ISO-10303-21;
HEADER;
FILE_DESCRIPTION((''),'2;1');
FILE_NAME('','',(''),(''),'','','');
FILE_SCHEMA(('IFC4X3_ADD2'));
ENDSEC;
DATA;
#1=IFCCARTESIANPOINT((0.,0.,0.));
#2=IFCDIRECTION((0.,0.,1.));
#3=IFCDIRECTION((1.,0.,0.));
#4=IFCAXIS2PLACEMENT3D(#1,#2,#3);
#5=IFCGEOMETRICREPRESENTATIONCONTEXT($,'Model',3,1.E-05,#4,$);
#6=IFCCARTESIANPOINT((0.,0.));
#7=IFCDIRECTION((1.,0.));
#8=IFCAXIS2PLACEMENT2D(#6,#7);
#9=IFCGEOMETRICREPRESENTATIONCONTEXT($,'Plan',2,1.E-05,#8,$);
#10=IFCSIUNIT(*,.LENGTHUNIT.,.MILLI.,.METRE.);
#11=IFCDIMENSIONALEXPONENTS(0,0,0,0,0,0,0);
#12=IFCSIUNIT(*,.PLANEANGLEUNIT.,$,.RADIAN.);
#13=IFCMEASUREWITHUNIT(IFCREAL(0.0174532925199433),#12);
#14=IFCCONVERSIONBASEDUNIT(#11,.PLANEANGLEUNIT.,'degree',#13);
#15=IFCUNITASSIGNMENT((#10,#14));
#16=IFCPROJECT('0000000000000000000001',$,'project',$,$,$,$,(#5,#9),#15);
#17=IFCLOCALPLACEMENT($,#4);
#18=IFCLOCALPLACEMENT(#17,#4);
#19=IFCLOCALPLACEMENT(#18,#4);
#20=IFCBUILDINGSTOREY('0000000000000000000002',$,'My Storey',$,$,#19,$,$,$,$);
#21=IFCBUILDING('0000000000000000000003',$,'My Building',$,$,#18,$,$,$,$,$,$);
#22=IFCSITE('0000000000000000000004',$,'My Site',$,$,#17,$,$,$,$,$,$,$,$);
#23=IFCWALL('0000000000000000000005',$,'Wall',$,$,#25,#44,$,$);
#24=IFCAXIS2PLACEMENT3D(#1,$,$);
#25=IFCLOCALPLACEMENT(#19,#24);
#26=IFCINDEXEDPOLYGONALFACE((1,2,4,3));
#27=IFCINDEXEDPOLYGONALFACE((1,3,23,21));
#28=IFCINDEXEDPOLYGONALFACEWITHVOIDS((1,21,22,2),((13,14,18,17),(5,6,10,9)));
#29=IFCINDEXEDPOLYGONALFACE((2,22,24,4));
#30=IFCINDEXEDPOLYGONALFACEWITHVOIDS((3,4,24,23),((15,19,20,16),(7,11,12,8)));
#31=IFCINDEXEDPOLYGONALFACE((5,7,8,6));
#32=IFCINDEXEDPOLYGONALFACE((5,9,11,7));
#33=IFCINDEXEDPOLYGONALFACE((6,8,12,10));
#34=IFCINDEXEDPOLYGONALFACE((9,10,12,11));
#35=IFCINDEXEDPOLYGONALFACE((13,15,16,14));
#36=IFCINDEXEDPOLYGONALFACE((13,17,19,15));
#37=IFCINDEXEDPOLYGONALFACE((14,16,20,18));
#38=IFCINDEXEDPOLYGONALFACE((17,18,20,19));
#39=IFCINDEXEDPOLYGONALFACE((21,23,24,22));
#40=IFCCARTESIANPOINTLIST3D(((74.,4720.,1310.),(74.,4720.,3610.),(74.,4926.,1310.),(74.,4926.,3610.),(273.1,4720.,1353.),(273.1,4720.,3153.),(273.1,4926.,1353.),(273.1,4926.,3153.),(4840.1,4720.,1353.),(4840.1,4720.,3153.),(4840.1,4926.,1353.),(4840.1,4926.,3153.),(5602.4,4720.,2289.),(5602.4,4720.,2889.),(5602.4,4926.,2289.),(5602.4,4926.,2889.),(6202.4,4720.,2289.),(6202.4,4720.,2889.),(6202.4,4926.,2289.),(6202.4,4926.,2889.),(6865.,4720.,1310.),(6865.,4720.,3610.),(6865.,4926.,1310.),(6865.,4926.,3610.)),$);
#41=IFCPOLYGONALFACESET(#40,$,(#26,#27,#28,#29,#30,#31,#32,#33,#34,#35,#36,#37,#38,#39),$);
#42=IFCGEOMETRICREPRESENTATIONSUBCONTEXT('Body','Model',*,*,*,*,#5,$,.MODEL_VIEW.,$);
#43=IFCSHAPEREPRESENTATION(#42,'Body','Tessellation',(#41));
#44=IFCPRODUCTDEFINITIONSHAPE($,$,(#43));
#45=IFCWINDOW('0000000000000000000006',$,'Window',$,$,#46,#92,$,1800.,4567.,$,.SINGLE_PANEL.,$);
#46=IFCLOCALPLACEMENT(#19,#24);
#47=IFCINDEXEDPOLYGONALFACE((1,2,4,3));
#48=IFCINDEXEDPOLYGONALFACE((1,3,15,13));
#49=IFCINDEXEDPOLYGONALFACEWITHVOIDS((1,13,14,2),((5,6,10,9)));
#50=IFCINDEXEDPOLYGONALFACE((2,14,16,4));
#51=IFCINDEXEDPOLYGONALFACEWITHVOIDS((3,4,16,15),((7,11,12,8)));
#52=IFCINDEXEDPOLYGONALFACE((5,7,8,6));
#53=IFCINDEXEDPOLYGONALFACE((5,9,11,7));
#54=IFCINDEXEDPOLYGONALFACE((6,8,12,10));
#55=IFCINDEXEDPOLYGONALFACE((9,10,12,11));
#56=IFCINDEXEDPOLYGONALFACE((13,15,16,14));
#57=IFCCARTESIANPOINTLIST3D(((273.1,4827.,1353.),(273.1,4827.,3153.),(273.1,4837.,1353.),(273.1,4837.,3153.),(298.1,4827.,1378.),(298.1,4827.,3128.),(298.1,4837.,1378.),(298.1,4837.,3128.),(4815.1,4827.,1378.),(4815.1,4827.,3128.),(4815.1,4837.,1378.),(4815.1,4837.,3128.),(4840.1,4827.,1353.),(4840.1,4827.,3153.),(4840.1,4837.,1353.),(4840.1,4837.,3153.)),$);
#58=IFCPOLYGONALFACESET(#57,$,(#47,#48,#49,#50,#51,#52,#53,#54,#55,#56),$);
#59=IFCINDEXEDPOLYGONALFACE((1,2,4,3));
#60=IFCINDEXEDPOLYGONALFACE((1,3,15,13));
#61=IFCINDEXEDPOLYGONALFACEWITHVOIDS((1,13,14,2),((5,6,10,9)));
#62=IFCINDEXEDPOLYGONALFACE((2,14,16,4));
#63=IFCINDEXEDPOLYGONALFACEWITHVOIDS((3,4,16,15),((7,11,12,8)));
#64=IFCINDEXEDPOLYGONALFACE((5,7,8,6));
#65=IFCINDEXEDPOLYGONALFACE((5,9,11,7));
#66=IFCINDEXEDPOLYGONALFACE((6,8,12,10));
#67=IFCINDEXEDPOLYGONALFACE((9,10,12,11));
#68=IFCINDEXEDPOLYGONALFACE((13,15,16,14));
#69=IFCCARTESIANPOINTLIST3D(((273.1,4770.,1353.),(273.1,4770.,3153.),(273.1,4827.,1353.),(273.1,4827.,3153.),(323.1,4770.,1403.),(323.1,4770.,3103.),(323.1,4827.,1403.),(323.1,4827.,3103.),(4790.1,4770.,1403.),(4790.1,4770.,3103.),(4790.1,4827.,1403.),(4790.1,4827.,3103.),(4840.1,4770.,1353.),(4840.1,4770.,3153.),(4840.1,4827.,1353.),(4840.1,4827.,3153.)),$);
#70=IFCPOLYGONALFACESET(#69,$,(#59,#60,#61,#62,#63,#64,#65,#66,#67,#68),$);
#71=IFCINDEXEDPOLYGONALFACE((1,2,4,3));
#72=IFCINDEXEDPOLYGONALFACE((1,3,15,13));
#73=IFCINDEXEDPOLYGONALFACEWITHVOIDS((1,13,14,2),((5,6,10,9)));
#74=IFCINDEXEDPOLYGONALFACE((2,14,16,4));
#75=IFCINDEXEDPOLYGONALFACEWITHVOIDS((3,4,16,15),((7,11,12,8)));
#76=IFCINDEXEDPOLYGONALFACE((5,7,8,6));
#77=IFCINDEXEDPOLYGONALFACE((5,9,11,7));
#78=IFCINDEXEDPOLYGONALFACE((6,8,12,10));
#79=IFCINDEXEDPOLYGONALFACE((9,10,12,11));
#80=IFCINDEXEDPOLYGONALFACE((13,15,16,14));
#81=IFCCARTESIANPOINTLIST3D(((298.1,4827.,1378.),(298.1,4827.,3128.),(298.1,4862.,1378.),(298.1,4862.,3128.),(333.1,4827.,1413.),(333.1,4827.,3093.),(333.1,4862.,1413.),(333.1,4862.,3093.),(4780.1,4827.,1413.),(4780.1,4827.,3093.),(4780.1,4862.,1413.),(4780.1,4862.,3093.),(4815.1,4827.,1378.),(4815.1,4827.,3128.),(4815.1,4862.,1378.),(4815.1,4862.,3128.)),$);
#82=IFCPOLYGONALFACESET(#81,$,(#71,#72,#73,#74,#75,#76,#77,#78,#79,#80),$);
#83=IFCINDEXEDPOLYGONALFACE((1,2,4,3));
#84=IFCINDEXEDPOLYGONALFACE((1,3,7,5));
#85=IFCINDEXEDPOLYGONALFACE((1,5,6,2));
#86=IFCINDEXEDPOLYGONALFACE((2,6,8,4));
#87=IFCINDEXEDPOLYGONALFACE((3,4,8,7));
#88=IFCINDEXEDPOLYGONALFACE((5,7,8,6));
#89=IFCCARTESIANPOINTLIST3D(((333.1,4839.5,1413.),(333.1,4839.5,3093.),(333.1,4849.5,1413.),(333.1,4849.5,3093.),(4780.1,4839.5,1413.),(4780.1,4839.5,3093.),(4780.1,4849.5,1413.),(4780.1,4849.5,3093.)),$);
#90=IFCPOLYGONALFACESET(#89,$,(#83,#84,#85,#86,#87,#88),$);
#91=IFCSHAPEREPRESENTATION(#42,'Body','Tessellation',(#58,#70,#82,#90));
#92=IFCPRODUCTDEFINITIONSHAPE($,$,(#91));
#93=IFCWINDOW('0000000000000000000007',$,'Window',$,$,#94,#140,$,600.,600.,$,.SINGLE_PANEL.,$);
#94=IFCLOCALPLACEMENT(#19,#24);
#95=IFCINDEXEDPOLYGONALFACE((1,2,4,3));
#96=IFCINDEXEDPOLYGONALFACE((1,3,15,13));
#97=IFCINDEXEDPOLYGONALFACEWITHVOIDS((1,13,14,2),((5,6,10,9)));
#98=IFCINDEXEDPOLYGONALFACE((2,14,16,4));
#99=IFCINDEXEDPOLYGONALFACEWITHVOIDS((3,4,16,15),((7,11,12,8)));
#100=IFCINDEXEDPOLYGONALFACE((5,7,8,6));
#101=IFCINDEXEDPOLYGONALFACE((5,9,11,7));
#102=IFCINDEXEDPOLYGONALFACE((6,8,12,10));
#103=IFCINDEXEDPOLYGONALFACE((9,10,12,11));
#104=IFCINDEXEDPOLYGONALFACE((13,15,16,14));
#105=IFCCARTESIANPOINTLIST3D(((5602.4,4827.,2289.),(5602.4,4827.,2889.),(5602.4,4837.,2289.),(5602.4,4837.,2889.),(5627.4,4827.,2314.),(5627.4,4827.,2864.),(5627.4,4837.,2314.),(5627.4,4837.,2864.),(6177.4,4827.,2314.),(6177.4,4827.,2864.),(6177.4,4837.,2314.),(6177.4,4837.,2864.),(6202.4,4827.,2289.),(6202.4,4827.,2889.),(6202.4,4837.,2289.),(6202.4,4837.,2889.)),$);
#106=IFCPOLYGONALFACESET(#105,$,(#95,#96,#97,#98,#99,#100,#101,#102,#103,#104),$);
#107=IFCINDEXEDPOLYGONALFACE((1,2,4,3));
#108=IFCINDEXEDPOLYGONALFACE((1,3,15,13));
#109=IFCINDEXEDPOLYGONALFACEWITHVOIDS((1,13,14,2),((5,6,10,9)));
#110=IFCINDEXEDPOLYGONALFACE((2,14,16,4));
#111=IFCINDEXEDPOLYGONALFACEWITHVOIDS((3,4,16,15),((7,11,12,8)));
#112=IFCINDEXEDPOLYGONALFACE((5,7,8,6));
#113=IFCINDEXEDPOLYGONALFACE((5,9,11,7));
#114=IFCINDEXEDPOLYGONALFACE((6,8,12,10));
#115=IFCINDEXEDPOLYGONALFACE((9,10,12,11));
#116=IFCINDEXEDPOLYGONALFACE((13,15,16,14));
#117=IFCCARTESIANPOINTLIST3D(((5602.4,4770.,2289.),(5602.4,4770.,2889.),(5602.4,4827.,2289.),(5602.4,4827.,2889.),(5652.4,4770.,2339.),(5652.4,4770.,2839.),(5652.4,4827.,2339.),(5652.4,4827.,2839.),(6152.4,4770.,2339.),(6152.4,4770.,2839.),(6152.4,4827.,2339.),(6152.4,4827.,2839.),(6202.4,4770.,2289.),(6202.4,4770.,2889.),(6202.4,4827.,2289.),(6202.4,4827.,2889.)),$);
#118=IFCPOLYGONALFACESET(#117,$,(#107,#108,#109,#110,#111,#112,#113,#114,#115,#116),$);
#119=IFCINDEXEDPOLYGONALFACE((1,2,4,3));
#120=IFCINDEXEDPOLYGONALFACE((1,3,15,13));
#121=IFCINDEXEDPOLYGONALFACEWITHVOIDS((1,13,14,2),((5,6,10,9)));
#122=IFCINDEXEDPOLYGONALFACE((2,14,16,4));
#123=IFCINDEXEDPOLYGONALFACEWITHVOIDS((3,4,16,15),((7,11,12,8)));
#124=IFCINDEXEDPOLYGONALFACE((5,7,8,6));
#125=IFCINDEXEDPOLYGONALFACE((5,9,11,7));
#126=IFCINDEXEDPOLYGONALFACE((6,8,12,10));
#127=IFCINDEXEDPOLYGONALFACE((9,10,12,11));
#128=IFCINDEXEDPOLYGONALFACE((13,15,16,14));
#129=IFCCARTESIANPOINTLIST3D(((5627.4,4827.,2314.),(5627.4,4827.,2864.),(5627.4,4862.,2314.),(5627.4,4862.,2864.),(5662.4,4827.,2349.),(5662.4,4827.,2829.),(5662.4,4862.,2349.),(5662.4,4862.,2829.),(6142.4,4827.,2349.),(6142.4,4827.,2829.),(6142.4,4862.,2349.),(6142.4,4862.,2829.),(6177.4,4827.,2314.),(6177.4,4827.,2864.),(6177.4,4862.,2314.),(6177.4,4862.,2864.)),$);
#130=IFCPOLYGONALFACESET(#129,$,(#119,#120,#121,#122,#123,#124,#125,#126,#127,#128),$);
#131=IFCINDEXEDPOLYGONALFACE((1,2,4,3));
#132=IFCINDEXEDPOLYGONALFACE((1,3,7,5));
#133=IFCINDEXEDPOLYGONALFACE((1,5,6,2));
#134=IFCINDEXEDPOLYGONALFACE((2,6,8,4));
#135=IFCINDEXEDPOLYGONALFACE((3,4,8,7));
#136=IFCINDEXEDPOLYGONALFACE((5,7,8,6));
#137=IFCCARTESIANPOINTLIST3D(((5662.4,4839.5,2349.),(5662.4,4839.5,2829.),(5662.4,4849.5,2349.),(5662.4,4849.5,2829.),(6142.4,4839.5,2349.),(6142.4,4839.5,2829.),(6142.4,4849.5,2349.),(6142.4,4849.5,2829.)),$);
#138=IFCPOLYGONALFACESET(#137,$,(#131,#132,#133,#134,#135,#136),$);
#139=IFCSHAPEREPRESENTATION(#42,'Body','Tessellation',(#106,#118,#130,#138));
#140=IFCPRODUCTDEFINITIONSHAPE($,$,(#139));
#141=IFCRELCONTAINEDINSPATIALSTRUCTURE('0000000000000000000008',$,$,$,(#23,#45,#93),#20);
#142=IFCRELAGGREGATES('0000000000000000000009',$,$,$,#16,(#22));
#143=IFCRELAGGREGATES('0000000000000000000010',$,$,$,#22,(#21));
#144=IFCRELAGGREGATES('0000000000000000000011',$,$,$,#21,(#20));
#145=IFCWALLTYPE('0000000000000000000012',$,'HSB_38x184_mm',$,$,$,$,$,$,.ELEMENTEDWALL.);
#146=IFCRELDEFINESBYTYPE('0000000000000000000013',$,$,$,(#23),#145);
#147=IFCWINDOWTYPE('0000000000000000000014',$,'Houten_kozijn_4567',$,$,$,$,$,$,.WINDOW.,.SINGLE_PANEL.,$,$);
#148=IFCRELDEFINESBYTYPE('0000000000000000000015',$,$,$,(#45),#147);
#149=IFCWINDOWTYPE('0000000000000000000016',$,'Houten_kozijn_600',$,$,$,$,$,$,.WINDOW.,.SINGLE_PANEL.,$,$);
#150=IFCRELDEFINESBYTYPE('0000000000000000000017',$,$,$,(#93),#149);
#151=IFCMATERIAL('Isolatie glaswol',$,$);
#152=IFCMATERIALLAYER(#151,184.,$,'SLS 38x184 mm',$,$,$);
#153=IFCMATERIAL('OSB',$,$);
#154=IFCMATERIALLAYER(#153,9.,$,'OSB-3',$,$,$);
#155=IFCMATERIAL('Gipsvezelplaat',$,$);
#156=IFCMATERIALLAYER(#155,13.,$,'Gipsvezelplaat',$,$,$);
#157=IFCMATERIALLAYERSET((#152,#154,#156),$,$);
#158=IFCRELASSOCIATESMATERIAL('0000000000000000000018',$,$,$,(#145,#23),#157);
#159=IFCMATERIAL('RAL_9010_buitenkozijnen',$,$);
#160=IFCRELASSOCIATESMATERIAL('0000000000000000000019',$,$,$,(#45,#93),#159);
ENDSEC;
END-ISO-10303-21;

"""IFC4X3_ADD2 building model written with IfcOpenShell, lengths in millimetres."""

from ifc_helpers import new_model, entity, si_unit, converted_unit, frame, origin_with_axes, origin_2d_with_axis, place, context, subcontext, project, spatial, line, indexed_curve, outline, extrude, shape, source, transform, mapped, material, layer, layer_set, layer_usage, type_object, type_shapes, element, fill, save


model = new_model("IFC4X3_ADD2")

# Units and contexts
model_context = context("Model", 3, precision=1e-05, world=origin_with_axes())
plan_context = context("Plan", 2, precision=1e-05, world=origin_2d_with_axis())
body_context_1 = subcontext(model_context, "Body", "Model", "MODEL_VIEW")
body_context_2 = subcontext(plan_context, "Body", "Plan", "PLAN_VIEW")
ifc_project = project(units=[si_unit("LENGTHUNIT", "METRE", prefix="MILLI"), converted_unit("PLANEANGLEUNIT", "degree", entity("IfcReal", 0.0174532925199433), si_unit("PLANEANGLEUNIT", "RADIAN"), dimensions=[0, 0, 0, 0, 0, 0, 0])], contexts=[model_context, plan_context])

# Site, building, storey
site_placement = place(None, origin_with_axes())
site = spatial("IfcSite", under=ifc_project, at=site_placement, Name="My Site")
building_placement = place(site_placement, origin_with_axes())
building = spatial("IfcBuilding", under=site, at=building_placement, Name="My Building")
storey_placement = place(building_placement, origin_with_axes())
storey = spatial("IfcBuildingStorey", under=building, at=storey_placement, Name="My Storey")

# Shared definitions
ifc_material_1 = material(Name="Isolatie glaswol")

# Shared definitions
ifc_layer_1 = layer(ifc_material_1, 184.0, Name="SLS 38x184 mm")
ifc_material_2 = material(Name="OSB")
ifc_layer_2 = layer(ifc_material_2, 9.0, Name="OSB-3")
ifc_material_3 = material(Name="Gipsvezelplaat")
ifc_layer_3 = layer(ifc_material_3, 13.0, Name="Gipsvezelplaat")
ifc_layer_set_1 = layer_set([ifc_layer_1, ifc_layer_2, ifc_layer_3])
wall_type_1 = type_object("IfcWallType", Name="HSB_38x184_mm", PredefinedType="ELEMENTEDWALL", material=ifc_layer_set_1)
ifc_material_4 = material(Name="RAL_9010_buitenkozijnen")

# Wall, openings, windows
ifc_layer_usage_1 = layer_usage(ifc_layer_set_1, "AXIS2", "POSITIVE", 0.0)
wall_1_placement = place(storey_placement, frame((74.0, 4720.0, 1310.0), z_axis=(0.0, 0.0, 1.0), x_axis=(1.0, 0.0, 0.0)))
wall_1 = element("IfcWall", 1, at=wall_1_placement, inside=storey, type_object=wall_type_1, material=ifc_layer_usage_1, Name="Wall", context=body_context_1, shape_type="SweptSolid", body=[
    extrude(outline(indexed_curve([(0.0, 0.0), (0.0, 206.0), (6791.0, 206.0), (6791.0, 0.0), (0.0, 0.0)], self_intersect=False)), origin_with_axes(), (0.0, 0.0, 1.0), 2300.0),
])
shared_shape_1 = source(origin_with_axes(), body_context_1, "Body", "SweptSolid", [
    extrude(outline(indexed_curve([(0.0, 0.0), (4567.0, 0.0), (4567.0, 1800.0), (0.0, 1800.0)], segments=[line(1, 2, 3, 4, 1)])), frame((0.0, -600.0, 0.0), z_axis=(0.0, -1.0, 0.0), x_axis=(1.0, 0.0, 0.0)), (0.0, 0.0, -1.0), 1200.0),
])
opening_1_placement = place(wall_1_placement, frame((199.1, 0.0, 43.0), z_axis=(0.0, 0.0, 1.0), x_axis=(1.0, 0.0, 0.0)))
opening_1 = element("IfcOpeningElement", 2, at=opening_1_placement, cuts=wall_1, PredefinedType="OPENING", context=body_context_1, shape_type="MappedRepresentation", body=[
    mapped(shared_shape_1, transform((0.0, 0.0, 0.0), x_axis=(1.0, 0.0, 0.0), y_axis=(0.0, 1.0, 0.0), z_axis=(0.0, 0.0, 1.0), scale=1.0)),
])
shared_shape_2 = source(origin_with_axes(), body_context_1, "Body", "SweptSolid", [
    extrude(outline(indexed_curve([(0.0, 0.0), (600.0, 0.0), (600.0, 600.0), (0.0, 600.0)], segments=[line(1, 2, 3, 4, 1)])), frame((0.0, -600.0, 0.0), z_axis=(0.0, -1.0, 0.0), x_axis=(1.0, 0.0, 0.0)), (0.0, 0.0, -1.0), 1200.0),
])
opening_2_placement = place(wall_1_placement, frame((5528.4, 0.0, 979.0), z_axis=(0.0, 0.0, 1.0), x_axis=(1.0, 0.0, 0.0)))
opening_2 = element("IfcOpeningElement", 3, at=opening_2_placement, cuts=wall_1, PredefinedType="OPENING", context=body_context_1, shape_type="MappedRepresentation", body=[
    mapped(shared_shape_2, transform((0.0, 0.0, 0.0), x_axis=(1.0, 0.0, 0.0), y_axis=(0.0, 1.0, 0.0), z_axis=(0.0, 0.0, 1.0), scale=1.0)),
])
window_type_1 = type_object("IfcWindowType", Name="Houten_kozijn_4567", PartitioningType="SINGLE_PANEL", PredefinedType="WINDOW")
shared_shape_3 = source(origin_with_axes(), body_context_1, "Body", "SweptSolid", [
    extrude(outline(indexed_curve([(0.0, 0.0), (4567.0, 0.0), (4567.0, 1800.0), (0.0, 1800.0)], segments=[line(1, 2, 3, 4, 1)]), holes=[indexed_curve([(25.0, 25.0), (4542.0, 25.0), (4542.0, 1775.0), (25.0, 1775.0)], segments=[line(1, 2, 3, 4, 1)])]), frame((0.0, 107.0, 0.0), z_axis=(0.0, -1.0, 0.0), x_axis=(1.0, 0.0, 0.0)), (0.0, 0.0, -1.0), 10.0),
    extrude(outline(indexed_curve([(0.0, 0.0), (4567.0, 0.0), (4567.0, 1800.0), (0.0, 1800.0)], segments=[line(1, 2, 3, 4, 1)]), holes=[indexed_curve([(50.0, 50.0), (4517.0, 50.0), (4517.0, 1750.0), (50.0, 1750.0)], segments=[line(1, 2, 3, 4, 1)])]), frame((0.0, 50.0, 0.0), z_axis=(0.0, -1.0, 0.0), x_axis=(1.0, 0.0, 0.0)), (0.0, 0.0, -1.0), 57.0),
    extrude(outline(indexed_curve([(0.0, 0.0), (4517.0, 0.0), (4517.0, 1750.0), (0.0, 1750.0)], segments=[line(1, 2, 3, 4, 1)]), holes=[indexed_curve([(35.0, 35.0), (4482.0, 35.0), (4482.0, 1715.0), (35.0, 1715.0)], segments=[line(1, 2, 3, 4, 1)])]), frame((25.0, 107.0, 25.0), z_axis=(0.0, -1.0, 0.0), x_axis=(1.0, 0.0, 0.0)), (0.0, 0.0, -1.0), 35.0),
    extrude(outline(indexed_curve([(35.0, 35.0), (4482.0, 35.0), (4482.0, 1715.0), (35.0, 1715.0)], segments=[line(1, 2, 3, 4, 1)])), frame((25.0, 119.5, 25.0), z_axis=(0.0, -1.0, 0.0), x_axis=(1.0, 0.0, 0.0)), (0.0, 0.0, -1.0), 10.0),
])
shared_shape_4 = source(origin_with_axes(), body_context_2, "Body", "Curve2D", [
    entity("IfcIndexedPolyCurve", entity("IfcCartesianPointList2D", [[50.0, 50.0], [4517.0, 50.0]])),
    entity("IfcIndexedPolyCurve", entity("IfcCartesianPointList2D", [[0.0, 117.0], [25.0, 117.0], [25.0, 107.0], [50.0, 107.0], [50.0, 50.0], [0.0, 50.0]]), [entity("IfcLineIndex", [1, 2, 3, 4, 5, 6, 1])]),
    entity("IfcIndexedPolyCurve", entity("IfcCartesianPointList2D", [[4567.0, 117.0], [4542.0, 117.0], [4542.0, 107.0], [4517.0, 107.0], [4517.0, 50.0], [4567.0, 50.0]]), [entity("IfcLineIndex", [1, 2, 3, 4, 5, 6, 1])]),
    entity("IfcIndexedPolyCurve", entity("IfcCartesianPointList2D", [[25.0, 107.0], [60.0, 107.0], [60.0, 142.0], [25.0, 142.0]]), [entity("IfcLineIndex", [1, 2, 3, 4, 1])]),
    entity("IfcIndexedPolyCurve", entity("IfcCartesianPointList2D", [[4542.0, 107.0], [4507.0, 107.0], [4507.0, 142.0], [4542.0, 142.0]]), [entity("IfcLineIndex", [1, 2, 3, 4, 1])]),
    entity("IfcIndexedPolyCurve", entity("IfcCartesianPointList2D", [[60.0, 107.0], [4507.0, 107.0]])),
    entity("IfcIndexedPolyCurve", entity("IfcCartesianPointList2D", [[60.0, 142.0], [4507.0, 142.0]])),
    entity("IfcIndexedPolyCurve", entity("IfcCartesianPointList2D", [[60.0, 124.5], [4507.0, 124.5]])),
])
type_shapes(window_type_1, [shared_shape_3, shared_shape_4])
window_1_placement = place(opening_1_placement, origin_with_axes())
window_1 = element("IfcWindow", 4, at=window_1_placement, inside=storey, type_object=window_type_1, material=ifc_material_4, Name="Window", OverallHeight=1800.0, OverallWidth=4567.0, PartitioningType="SINGLE_PANEL", shapes=[
    shape(body_context_1, "Body", "MappedRepresentation", [mapped(shared_shape_3, transform((0.0, 0.0, 0.0), x_axis=(1.0, 0.0, 0.0), y_axis=(0.0, 1.0, 0.0), z_axis=(0.0, 0.0, 1.0), scale=1.0))]),
    shape(body_context_2, "Body", "MappedRepresentation", [mapped(shared_shape_4, transform((0.0, 0.0, 0.0), x_axis=(1.0, 0.0, 0.0), y_axis=(0.0, 1.0, 0.0), z_axis=(0.0, 0.0, 1.0), scale=1.0))]),
])
fill(opening_1, window_1)
window_type_2 = type_object("IfcWindowType", Name="Houten_kozijn_600", PartitioningType="SINGLE_PANEL", PredefinedType="WINDOW")
shared_shape_5 = source(origin_with_axes(), body_context_1, "Body", "SweptSolid", [
    extrude(outline(indexed_curve([(0.0, 0.0), (600.0, 0.0), (600.0, 600.0), (0.0, 600.0)], segments=[line(1, 2, 3, 4, 1)]), holes=[indexed_curve([(25.0, 25.0), (575.0, 25.0), (575.0, 575.0), (25.0, 575.0)], segments=[line(1, 2, 3, 4, 1)])]), frame((0.0, 107.0, 0.0), z_axis=(0.0, -1.0, 0.0), x_axis=(1.0, 0.0, 0.0)), (0.0, 0.0, -1.0), 10.0),
    extrude(outline(indexed_curve([(0.0, 0.0), (600.0, 0.0), (600.0, 600.0), (0.0, 600.0)], segments=[line(1, 2, 3, 4, 1)]), holes=[indexed_curve([(50.0, 50.0), (550.0, 50.0), (550.0, 550.0), (50.0, 550.0)], segments=[line(1, 2, 3, 4, 1)])]), frame((0.0, 50.0, 0.0), z_axis=(0.0, -1.0, 0.0), x_axis=(1.0, 0.0, 0.0)), (0.0, 0.0, -1.0), 57.0),
    extrude(outline(indexed_curve([(0.0, 0.0), (550.0, 0.0), (550.0, 550.0), (0.0, 550.0)], segments=[line(1, 2, 3, 4, 1)]), holes=[indexed_curve([(35.0, 35.0), (515.0, 35.0), (515.0, 515.0), (35.0, 515.0)], segments=[line(1, 2, 3, 4, 1)])]), frame((25.0, 107.0, 25.0), z_axis=(0.0, -1.0, 0.0), x_axis=(1.0, 0.0, 0.0)), (0.0, 0.0, -1.0), 35.0),
    extrude(outline(indexed_curve([(35.0, 35.0), (515.0, 35.0), (515.0, 515.0), (35.0, 515.0)], segments=[line(1, 2, 3, 4, 1)])), frame((25.0, 119.5, 25.0), z_axis=(0.0, -1.0, 0.0), x_axis=(1.0, 0.0, 0.0)), (0.0, 0.0, -1.0), 10.0),
])
shared_shape_6 = source(origin_with_axes(), body_context_2, "Body", "Curve2D", [
    entity("IfcIndexedPolyCurve", entity("IfcCartesianPointList2D", [[50.0, 50.0], [550.0, 50.0]])),
    entity("IfcIndexedPolyCurve", entity("IfcCartesianPointList2D", [[0.0, 117.0], [25.0, 117.0], [25.0, 107.0], [50.0, 107.0], [50.0, 50.0], [0.0, 50.0]]), [entity("IfcLineIndex", [1, 2, 3, 4, 5, 6, 1])]),
    entity("IfcIndexedPolyCurve", entity("IfcCartesianPointList2D", [[600.0, 117.0], [575.0, 117.0], [575.0, 107.0], [550.0, 107.0], [550.0, 50.0], [600.0, 50.0]]), [entity("IfcLineIndex", [1, 2, 3, 4, 5, 6, 1])]),
    entity("IfcIndexedPolyCurve", entity("IfcCartesianPointList2D", [[25.0, 107.0], [60.0, 107.0], [60.0, 142.0], [25.0, 142.0]]), [entity("IfcLineIndex", [1, 2, 3, 4, 1])]),
    entity("IfcIndexedPolyCurve", entity("IfcCartesianPointList2D", [[575.0, 107.0], [540.0, 107.0], [540.0, 142.0], [575.0, 142.0]]), [entity("IfcLineIndex", [1, 2, 3, 4, 1])]),
    entity("IfcIndexedPolyCurve", entity("IfcCartesianPointList2D", [[60.0, 107.0], [540.0, 107.0]])),
    entity("IfcIndexedPolyCurve", entity("IfcCartesianPointList2D", [[60.0, 142.0], [540.0, 142.0]])),
    entity("IfcIndexedPolyCurve", entity("IfcCartesianPointList2D", [[60.0, 124.5], [540.0, 124.5]])),
])
type_shapes(window_type_2, [shared_shape_5, shared_shape_6])
window_2_placement = place(opening_2_placement, origin_with_axes())
window_2 = element("IfcWindow", 5, at=window_2_placement, inside=storey, type_object=window_type_2, material=ifc_material_4, Name="Window", OverallHeight=600.0, OverallWidth=600.0, PartitioningType="SINGLE_PANEL", shapes=[
    shape(body_context_1, "Body", "MappedRepresentation", [mapped(shared_shape_5, transform((0.0, 0.0, 0.0), x_axis=(1.0, 0.0, 0.0), y_axis=(0.0, 1.0, 0.0), z_axis=(0.0, 0.0, 1.0), scale=1.0))]),
    shape(body_context_2, "Body", "MappedRepresentation", [mapped(shared_shape_6, transform((0.0, 0.0, 0.0), x_axis=(1.0, 0.0, 0.0), y_axis=(0.0, 1.0, 0.0), z_axis=(0.0, 0.0, 1.0), scale=1.0))]),
])
fill(opening_2, window_2)

save(model, "model.ifc")
